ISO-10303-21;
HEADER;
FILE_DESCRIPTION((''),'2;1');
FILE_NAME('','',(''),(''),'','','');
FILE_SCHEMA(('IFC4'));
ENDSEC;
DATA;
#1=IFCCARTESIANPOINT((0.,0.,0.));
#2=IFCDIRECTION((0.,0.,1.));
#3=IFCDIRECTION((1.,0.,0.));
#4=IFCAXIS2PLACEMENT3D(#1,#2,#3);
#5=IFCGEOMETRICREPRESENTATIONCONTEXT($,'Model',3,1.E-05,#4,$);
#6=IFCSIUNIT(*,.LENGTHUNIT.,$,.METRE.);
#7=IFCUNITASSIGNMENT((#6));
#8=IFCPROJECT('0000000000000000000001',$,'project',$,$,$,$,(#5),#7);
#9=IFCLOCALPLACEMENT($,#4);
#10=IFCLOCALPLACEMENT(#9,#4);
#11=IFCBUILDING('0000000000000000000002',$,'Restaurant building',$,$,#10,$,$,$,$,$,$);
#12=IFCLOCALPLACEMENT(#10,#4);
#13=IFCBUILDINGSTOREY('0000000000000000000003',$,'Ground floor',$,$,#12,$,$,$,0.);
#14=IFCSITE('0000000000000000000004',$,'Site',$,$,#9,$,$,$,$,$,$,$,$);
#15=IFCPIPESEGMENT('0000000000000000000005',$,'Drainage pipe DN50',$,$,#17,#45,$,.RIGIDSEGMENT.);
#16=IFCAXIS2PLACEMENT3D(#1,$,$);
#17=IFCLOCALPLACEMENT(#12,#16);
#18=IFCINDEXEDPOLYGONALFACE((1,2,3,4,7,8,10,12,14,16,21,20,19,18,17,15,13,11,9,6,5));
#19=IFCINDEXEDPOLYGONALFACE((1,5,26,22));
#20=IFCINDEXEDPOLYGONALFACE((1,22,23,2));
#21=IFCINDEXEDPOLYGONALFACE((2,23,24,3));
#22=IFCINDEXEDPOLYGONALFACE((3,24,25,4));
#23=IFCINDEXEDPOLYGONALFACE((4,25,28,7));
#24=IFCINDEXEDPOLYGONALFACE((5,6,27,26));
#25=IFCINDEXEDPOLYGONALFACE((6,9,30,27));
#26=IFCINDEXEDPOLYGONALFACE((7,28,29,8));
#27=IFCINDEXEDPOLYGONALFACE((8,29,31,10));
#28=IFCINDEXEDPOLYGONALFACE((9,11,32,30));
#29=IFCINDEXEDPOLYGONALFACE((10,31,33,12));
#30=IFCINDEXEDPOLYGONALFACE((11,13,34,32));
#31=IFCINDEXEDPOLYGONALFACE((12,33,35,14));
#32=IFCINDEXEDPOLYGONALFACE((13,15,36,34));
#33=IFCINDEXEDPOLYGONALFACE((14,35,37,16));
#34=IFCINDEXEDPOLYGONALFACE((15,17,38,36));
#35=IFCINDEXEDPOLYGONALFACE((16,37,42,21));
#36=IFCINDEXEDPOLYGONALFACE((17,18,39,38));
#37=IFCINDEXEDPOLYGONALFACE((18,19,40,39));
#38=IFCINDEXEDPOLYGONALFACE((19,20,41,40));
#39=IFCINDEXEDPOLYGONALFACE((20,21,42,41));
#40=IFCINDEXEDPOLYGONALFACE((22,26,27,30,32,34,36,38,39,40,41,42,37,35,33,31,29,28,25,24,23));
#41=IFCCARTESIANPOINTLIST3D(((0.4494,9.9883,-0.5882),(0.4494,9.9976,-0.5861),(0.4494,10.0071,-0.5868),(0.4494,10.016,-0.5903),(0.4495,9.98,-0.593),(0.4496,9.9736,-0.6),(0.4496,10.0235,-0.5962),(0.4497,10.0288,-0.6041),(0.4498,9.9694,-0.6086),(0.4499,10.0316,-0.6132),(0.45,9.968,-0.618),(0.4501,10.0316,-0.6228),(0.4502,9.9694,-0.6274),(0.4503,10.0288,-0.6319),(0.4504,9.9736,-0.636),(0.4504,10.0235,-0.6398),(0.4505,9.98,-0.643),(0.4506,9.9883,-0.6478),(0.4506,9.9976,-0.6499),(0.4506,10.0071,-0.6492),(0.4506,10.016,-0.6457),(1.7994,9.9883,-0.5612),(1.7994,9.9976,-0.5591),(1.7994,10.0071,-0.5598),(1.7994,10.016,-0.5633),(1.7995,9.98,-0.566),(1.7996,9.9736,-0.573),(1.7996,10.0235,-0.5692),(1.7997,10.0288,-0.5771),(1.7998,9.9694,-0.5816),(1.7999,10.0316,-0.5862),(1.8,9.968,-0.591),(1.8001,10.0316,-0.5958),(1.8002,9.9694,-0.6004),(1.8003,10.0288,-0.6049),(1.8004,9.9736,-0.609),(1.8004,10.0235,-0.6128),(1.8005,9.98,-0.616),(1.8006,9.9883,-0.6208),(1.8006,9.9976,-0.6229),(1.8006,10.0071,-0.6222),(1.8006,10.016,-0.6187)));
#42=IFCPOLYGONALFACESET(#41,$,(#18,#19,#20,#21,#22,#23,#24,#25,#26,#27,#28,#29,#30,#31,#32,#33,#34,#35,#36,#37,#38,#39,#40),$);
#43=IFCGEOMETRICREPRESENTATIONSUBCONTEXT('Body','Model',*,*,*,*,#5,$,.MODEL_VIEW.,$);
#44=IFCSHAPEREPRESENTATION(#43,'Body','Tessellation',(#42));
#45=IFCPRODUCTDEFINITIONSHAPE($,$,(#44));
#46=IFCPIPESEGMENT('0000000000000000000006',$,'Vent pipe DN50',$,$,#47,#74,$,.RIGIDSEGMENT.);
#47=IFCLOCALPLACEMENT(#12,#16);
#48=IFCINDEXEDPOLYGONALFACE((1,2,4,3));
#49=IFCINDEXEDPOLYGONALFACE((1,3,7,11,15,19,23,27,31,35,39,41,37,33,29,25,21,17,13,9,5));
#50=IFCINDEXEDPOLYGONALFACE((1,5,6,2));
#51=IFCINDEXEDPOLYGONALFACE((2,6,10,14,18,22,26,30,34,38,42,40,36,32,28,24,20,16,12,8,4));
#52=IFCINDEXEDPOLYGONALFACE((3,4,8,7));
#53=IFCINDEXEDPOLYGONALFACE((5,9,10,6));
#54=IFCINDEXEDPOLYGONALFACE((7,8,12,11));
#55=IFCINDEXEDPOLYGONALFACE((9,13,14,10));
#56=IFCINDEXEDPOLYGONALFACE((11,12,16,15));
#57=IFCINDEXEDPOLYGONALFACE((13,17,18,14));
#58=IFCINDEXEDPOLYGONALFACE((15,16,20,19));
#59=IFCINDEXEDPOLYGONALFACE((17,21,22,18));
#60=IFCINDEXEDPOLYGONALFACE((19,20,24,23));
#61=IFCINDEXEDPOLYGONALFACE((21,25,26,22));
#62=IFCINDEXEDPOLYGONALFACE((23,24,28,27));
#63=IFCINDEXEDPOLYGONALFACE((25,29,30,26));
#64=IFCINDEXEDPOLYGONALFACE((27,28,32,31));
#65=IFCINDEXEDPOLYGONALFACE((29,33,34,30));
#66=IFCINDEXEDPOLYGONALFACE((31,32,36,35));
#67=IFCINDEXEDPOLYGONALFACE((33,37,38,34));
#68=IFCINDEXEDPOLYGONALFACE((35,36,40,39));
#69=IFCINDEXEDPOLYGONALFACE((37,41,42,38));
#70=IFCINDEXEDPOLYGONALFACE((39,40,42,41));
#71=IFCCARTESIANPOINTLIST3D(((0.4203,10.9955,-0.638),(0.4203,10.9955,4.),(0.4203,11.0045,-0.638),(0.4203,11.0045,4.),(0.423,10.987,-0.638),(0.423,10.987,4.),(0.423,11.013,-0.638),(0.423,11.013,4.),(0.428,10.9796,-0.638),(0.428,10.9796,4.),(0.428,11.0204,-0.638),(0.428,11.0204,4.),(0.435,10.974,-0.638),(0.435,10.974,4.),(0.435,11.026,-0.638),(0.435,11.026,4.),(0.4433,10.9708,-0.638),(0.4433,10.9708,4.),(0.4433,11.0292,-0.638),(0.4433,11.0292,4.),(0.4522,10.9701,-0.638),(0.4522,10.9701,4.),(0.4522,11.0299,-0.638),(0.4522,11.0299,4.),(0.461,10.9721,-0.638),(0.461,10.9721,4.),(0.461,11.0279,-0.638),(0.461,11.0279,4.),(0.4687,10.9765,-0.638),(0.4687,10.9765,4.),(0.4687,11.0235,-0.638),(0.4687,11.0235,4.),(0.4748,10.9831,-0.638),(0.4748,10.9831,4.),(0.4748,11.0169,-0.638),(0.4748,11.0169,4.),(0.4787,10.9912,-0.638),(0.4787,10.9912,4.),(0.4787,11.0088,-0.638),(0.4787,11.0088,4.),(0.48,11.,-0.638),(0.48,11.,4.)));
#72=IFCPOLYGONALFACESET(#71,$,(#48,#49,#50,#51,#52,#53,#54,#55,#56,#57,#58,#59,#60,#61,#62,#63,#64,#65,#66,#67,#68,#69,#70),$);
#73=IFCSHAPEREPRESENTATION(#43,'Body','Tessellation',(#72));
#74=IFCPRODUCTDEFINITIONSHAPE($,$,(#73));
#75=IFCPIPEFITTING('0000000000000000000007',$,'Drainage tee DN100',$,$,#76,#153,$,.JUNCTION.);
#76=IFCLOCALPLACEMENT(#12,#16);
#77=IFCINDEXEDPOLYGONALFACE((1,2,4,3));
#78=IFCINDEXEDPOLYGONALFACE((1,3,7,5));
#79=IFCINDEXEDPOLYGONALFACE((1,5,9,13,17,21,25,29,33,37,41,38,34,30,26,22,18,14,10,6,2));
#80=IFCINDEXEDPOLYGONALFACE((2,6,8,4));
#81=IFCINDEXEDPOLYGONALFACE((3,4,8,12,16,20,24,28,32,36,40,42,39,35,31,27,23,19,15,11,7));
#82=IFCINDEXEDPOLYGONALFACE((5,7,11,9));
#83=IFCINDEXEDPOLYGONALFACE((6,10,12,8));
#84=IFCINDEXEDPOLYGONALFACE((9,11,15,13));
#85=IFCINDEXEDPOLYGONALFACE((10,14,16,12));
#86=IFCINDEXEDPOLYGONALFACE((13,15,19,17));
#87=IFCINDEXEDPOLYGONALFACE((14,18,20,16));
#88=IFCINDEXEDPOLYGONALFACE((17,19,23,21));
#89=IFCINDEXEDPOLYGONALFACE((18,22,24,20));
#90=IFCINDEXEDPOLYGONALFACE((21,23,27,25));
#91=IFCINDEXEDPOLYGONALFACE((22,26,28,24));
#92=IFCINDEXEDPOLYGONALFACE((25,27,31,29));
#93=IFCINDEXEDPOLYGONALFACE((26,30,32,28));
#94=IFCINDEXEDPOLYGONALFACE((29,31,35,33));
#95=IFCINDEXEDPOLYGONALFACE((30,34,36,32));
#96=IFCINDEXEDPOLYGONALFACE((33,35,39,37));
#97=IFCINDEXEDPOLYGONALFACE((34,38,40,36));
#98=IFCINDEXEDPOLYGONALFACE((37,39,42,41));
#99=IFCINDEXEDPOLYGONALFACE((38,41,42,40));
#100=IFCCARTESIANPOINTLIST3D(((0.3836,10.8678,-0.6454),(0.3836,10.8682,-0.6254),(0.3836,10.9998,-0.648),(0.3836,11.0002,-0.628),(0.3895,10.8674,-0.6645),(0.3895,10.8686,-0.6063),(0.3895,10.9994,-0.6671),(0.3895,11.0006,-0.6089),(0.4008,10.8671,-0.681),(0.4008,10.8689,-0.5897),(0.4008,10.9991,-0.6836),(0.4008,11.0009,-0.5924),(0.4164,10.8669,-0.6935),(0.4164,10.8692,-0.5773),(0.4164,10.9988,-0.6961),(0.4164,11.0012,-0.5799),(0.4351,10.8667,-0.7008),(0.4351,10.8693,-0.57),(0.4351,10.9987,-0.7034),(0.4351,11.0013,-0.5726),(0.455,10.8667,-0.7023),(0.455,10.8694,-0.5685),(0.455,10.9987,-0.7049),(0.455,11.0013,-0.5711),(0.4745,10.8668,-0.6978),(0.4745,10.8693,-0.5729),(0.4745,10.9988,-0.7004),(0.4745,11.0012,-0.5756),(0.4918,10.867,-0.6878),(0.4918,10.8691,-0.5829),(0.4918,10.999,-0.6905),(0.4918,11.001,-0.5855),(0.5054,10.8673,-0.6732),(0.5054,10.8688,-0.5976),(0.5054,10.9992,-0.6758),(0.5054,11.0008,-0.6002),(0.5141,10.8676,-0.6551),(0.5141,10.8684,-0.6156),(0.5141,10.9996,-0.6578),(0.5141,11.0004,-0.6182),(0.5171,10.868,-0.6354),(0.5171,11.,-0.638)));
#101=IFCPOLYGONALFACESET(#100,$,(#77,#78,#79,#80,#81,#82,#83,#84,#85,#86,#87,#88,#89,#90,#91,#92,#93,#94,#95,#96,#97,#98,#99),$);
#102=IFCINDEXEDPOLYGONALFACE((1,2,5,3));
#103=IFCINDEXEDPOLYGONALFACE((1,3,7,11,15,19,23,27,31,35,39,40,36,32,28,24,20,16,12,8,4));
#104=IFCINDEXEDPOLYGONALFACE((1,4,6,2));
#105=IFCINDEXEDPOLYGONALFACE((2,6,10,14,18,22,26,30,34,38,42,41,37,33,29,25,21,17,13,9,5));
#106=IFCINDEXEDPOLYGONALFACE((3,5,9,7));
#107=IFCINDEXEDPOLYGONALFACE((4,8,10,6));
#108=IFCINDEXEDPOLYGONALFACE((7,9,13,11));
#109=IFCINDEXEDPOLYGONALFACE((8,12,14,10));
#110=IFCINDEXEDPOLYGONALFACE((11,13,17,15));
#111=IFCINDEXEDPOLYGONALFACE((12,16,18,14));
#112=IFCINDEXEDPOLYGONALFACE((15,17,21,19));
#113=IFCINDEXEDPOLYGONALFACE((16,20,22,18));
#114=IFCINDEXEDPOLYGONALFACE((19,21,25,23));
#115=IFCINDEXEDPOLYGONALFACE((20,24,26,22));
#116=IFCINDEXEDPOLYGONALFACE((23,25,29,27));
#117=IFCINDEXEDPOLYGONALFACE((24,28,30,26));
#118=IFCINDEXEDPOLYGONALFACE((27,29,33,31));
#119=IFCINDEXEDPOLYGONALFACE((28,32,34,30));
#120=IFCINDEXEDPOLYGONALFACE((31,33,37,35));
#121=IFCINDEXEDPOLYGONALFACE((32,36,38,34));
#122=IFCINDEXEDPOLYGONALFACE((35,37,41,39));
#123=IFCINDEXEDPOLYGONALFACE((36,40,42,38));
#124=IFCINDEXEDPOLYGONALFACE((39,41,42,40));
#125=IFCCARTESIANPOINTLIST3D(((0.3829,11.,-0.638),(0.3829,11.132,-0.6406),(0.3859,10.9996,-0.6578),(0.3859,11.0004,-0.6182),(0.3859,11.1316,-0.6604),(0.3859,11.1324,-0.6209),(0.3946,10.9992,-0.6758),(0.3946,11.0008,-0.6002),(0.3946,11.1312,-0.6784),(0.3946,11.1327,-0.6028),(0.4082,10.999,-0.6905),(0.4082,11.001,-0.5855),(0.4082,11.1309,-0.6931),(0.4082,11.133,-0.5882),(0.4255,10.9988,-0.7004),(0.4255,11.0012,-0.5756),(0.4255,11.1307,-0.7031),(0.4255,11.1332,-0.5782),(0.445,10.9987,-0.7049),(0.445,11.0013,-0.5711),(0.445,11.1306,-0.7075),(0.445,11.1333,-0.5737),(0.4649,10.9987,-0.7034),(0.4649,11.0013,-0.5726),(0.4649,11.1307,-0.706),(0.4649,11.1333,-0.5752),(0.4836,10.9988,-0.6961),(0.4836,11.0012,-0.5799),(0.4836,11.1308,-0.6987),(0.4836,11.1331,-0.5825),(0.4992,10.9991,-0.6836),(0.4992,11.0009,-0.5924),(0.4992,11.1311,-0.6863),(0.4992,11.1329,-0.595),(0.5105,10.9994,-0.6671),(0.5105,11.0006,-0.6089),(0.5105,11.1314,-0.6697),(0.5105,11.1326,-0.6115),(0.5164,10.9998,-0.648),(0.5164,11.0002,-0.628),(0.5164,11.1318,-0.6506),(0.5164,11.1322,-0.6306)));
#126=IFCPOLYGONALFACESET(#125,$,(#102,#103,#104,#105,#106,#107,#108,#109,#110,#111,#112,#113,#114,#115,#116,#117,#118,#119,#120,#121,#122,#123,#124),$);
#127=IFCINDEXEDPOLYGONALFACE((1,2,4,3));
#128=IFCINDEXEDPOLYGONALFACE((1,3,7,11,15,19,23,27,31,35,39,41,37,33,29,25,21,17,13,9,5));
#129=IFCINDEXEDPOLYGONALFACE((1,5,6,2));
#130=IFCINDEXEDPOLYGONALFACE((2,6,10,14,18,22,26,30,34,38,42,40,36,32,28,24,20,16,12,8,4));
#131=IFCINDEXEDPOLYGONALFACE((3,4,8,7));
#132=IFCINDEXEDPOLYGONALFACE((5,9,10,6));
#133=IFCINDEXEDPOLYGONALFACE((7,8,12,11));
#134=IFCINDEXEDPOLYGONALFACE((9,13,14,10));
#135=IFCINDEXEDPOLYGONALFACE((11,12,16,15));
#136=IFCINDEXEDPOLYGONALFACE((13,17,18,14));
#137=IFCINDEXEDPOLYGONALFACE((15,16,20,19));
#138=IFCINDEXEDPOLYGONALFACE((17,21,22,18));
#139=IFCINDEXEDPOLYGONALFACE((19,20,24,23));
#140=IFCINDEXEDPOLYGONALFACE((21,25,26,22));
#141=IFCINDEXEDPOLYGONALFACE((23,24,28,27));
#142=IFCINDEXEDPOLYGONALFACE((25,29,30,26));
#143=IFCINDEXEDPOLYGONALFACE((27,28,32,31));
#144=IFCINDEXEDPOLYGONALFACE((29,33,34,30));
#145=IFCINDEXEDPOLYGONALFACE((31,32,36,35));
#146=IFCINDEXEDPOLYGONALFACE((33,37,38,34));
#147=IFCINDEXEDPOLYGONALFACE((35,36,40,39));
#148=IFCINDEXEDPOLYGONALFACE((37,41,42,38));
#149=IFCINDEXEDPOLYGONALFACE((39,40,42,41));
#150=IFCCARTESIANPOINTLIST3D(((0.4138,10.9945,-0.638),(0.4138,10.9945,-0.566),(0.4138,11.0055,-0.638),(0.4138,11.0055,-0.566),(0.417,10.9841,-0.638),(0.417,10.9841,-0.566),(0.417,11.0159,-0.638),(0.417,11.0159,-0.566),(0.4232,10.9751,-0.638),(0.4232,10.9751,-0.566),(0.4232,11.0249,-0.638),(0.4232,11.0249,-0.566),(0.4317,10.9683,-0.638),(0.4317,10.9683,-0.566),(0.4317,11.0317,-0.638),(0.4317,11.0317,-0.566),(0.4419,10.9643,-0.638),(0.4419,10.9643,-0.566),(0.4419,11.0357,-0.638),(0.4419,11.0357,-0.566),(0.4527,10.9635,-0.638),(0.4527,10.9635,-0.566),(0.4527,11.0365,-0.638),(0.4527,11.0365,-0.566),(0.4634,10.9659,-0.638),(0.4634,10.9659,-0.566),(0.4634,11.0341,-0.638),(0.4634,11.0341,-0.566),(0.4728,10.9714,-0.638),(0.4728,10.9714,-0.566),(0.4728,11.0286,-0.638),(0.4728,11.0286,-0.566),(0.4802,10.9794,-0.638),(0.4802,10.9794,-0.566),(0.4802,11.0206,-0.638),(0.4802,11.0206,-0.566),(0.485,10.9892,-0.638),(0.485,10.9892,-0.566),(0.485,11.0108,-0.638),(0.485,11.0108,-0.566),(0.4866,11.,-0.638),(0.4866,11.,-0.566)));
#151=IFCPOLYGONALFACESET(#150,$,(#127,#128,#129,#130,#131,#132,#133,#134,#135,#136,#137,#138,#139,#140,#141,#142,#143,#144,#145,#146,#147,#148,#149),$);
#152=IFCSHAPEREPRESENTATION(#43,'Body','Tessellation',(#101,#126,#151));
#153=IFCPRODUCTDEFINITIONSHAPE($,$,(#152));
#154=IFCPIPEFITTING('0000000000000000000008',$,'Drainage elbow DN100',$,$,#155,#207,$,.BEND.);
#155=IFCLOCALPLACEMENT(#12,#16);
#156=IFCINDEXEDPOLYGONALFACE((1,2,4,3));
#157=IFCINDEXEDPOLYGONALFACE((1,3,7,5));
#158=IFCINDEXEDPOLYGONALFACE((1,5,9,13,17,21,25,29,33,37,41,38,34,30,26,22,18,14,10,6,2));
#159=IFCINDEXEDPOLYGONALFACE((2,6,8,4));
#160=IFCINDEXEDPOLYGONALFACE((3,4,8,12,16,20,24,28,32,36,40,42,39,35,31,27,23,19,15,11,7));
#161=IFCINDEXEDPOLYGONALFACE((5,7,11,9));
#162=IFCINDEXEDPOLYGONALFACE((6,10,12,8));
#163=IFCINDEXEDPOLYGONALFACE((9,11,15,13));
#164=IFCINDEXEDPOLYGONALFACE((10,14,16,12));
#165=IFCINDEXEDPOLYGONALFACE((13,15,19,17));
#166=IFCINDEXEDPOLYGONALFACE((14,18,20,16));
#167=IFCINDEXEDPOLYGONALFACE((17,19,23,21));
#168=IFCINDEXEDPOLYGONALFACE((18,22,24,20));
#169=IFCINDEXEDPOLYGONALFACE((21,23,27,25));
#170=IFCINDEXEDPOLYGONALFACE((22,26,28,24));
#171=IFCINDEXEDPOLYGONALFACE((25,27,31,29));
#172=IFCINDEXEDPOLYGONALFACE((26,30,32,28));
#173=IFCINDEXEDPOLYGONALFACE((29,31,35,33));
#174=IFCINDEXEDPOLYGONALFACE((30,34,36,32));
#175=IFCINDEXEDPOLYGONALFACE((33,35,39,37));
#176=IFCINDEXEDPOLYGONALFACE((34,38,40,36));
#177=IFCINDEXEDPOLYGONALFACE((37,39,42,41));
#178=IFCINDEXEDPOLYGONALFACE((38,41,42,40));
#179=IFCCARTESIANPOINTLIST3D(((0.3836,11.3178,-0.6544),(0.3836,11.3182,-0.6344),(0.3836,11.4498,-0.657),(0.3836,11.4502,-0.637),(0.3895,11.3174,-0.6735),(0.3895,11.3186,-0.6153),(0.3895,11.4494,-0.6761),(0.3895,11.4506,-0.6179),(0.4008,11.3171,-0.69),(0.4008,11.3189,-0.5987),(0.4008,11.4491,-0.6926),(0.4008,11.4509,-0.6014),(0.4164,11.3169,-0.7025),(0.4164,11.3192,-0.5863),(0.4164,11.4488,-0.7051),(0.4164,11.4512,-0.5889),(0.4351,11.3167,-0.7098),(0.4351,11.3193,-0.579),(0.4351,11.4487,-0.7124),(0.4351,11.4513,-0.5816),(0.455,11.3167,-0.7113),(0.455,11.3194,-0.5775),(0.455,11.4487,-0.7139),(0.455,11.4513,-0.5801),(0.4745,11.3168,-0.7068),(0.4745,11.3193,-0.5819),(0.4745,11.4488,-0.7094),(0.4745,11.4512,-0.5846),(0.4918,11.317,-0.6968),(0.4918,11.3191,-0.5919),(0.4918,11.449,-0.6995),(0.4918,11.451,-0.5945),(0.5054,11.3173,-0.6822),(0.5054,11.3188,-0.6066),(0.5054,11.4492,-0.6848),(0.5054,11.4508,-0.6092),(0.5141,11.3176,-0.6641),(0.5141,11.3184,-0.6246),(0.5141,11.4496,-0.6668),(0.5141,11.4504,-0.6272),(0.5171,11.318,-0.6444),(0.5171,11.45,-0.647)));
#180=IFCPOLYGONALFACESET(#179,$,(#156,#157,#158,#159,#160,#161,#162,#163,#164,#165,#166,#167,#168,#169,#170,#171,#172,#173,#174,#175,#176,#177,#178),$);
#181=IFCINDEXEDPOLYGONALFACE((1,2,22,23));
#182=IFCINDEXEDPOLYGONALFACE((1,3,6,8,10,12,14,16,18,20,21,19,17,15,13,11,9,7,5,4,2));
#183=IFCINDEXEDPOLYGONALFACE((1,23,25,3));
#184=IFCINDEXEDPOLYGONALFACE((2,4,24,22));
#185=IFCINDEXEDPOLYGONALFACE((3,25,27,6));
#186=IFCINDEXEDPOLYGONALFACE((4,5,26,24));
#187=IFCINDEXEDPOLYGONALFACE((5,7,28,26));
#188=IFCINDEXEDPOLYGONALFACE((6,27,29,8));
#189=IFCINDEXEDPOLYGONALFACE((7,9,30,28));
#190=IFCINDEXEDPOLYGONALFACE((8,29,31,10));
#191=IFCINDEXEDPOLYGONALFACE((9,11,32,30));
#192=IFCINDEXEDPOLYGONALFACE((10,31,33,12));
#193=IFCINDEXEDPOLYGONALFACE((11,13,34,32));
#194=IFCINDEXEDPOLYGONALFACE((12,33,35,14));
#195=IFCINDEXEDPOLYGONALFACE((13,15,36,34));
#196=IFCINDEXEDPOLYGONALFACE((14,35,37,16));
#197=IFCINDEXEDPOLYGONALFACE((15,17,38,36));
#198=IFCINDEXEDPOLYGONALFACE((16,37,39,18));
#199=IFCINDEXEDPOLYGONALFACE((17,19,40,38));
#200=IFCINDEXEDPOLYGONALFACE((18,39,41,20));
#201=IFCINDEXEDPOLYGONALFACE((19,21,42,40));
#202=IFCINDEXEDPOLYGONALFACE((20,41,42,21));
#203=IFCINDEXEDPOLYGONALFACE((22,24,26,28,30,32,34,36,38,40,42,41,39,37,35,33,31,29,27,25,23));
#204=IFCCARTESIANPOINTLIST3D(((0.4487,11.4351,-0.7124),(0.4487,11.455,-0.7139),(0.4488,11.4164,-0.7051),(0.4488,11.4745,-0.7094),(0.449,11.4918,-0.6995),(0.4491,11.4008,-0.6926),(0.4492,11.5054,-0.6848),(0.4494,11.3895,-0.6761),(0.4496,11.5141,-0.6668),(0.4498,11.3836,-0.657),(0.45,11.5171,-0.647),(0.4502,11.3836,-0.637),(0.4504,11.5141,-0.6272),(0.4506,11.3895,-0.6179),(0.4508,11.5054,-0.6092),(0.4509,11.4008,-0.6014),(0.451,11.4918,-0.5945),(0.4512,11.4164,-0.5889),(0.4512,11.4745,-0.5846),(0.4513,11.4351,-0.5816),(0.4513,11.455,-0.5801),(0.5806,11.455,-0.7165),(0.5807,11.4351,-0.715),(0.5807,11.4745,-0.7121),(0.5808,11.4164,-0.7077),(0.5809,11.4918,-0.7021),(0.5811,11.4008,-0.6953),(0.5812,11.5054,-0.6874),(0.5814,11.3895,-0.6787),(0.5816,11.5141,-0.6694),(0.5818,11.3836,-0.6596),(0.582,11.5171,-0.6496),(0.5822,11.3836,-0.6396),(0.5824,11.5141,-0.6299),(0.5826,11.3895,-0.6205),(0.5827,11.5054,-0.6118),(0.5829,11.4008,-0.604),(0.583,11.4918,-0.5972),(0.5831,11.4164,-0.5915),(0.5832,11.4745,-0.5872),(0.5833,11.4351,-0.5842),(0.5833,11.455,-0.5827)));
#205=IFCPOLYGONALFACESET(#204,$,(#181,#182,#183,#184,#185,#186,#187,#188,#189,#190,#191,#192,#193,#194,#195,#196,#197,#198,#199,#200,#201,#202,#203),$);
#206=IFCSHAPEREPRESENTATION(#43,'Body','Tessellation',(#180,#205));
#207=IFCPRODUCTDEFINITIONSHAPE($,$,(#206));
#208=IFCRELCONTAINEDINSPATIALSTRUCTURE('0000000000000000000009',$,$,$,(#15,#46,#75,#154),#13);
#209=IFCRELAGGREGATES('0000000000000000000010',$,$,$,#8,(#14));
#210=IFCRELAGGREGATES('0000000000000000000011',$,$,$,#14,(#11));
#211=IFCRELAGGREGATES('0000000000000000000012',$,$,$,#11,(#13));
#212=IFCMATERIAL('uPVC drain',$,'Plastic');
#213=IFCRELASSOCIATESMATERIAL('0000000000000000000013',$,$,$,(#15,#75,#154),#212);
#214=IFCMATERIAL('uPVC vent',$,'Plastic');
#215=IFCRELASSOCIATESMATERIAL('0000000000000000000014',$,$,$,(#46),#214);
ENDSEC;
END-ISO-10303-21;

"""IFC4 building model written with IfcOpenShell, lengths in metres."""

from ifc_helpers import new_model, si_unit, frame, origin, origin_with_axes, origin_2d, place, context, subcontext, project, spatial, circle, extrude, material, element, save


model = new_model("IFC4")

# Units and contexts
model_context = context("Model", 3, precision=1e-05, world=origin_with_axes())
body_context = subcontext(model_context, "Body", "Model", "MODEL_VIEW")
ifc_project = project(units=[si_unit("LENGTHUNIT", "METRE")], contexts=[model_context])

# Site, building, storey
site_placement = place(None, origin_with_axes())
site = spatial("IfcSite", under=ifc_project, at=site_placement, Name="Site")
building_placement = place(site_placement, origin_with_axes())
building = spatial("IfcBuilding", under=site, at=building_placement, Name="Restaurant building")
storey_placement = place(building_placement, origin_with_axes())
storey = spatial("IfcBuildingStorey", under=building, at=storey_placement, Name="Ground floor", Elevation=0.0)

# Shared definitions
ifc_material_1 = material(Name="uPVC drain", Category="Plastic")

# Shared definitions
ifc_material_2 = material(Name="uPVC vent", Category="Plastic")

# Pipe segments
pipe_segment_1_placement = place(storey_placement, frame((1.8, 10.0, -0.591)))
element("IfcPipeSegment", 1, at=pipe_segment_1_placement, inside=storey, material=ifc_material_1, Name="Drainage pipe DN50", PredefinedType="RIGIDSEGMENT", context=body_context, shape_type="SweptSolid", body=[
    extrude(circle(Radius=0.032, at=origin_2d()), frame((0.0, 0.0, 0.0), z_axis=(-0.9998, 0.0, -0.019996), x_axis=(0.0, -1.0, 0.0)), (0.0, 0.0, 1.0), 1.3503),
])
pipe_segment_2_placement = place(storey_placement, frame((0.45, 11.0, -0.638)))
element("IfcPipeSegment", 2, at=pipe_segment_2_placement, inside=storey, material=ifc_material_2, Name="Vent pipe DN50", PredefinedType="RIGIDSEGMENT", context=body_context, shape_type="SweptSolid", body=[
    extrude(circle(Radius=0.03, at=origin_2d()), origin(), (0.0, 0.0, 1.0), 4.638),
])

# Pipe fittings
pipe_fitting_1_placement = place(storey_placement, frame((0.45, 11.0, -0.638)))
element("IfcPipeFitting", 3, at=pipe_fitting_1_placement, inside=storey, material=ifc_material_1, Name="Drainage tee DN100", PredefinedType="JUNCTION", context=body_context, shape_type="SweptSolid", body=[
    extrude(circle(Radius=0.0671, at=origin_2d()), frame((0.0, 0.0, 0.0), z_axis=(0.0, -0.9998, 0.019996), x_axis=(1.0, 0.0, 0.0)), (0.0, 0.0, 1.0), 0.132),
    extrude(circle(Radius=0.0671, at=origin_2d()), frame((0.0, 0.0, 0.0), z_axis=(0.0, 0.9998, -0.019996), x_axis=(-1.0, 0.0, 0.0)), (0.0, 0.0, 1.0), 0.132),
    extrude(circle(Radius=0.0366, at=origin_2d()), origin(), (0.0, 0.0, 1.0), 0.072),
])
pipe_fitting_2_placement = place(storey_placement, frame((0.45, 11.45, -0.647)))
element("IfcPipeFitting", 4, at=pipe_fitting_2_placement, inside=storey, material=ifc_material_1, Name="Drainage elbow DN100", PredefinedType="BEND", context=body_context, shape_type="SweptSolid", body=[
    extrude(circle(Radius=0.0671, at=origin_2d()), frame((0.0, 0.0, 0.0), z_axis=(0.0, -0.9998, 0.019996), x_axis=(1.0, 0.0, 0.0)), (0.0, 0.0, 1.0), 0.132),
    extrude(circle(Radius=0.0671, at=origin_2d()), frame((0.0, 0.0, 0.0), z_axis=(0.9998, 0.0, -0.019996), x_axis=(0.0, 1.0, 0.0)), (0.0, 0.0, 1.0), 0.132),
])

save(model, "model.ifc")
